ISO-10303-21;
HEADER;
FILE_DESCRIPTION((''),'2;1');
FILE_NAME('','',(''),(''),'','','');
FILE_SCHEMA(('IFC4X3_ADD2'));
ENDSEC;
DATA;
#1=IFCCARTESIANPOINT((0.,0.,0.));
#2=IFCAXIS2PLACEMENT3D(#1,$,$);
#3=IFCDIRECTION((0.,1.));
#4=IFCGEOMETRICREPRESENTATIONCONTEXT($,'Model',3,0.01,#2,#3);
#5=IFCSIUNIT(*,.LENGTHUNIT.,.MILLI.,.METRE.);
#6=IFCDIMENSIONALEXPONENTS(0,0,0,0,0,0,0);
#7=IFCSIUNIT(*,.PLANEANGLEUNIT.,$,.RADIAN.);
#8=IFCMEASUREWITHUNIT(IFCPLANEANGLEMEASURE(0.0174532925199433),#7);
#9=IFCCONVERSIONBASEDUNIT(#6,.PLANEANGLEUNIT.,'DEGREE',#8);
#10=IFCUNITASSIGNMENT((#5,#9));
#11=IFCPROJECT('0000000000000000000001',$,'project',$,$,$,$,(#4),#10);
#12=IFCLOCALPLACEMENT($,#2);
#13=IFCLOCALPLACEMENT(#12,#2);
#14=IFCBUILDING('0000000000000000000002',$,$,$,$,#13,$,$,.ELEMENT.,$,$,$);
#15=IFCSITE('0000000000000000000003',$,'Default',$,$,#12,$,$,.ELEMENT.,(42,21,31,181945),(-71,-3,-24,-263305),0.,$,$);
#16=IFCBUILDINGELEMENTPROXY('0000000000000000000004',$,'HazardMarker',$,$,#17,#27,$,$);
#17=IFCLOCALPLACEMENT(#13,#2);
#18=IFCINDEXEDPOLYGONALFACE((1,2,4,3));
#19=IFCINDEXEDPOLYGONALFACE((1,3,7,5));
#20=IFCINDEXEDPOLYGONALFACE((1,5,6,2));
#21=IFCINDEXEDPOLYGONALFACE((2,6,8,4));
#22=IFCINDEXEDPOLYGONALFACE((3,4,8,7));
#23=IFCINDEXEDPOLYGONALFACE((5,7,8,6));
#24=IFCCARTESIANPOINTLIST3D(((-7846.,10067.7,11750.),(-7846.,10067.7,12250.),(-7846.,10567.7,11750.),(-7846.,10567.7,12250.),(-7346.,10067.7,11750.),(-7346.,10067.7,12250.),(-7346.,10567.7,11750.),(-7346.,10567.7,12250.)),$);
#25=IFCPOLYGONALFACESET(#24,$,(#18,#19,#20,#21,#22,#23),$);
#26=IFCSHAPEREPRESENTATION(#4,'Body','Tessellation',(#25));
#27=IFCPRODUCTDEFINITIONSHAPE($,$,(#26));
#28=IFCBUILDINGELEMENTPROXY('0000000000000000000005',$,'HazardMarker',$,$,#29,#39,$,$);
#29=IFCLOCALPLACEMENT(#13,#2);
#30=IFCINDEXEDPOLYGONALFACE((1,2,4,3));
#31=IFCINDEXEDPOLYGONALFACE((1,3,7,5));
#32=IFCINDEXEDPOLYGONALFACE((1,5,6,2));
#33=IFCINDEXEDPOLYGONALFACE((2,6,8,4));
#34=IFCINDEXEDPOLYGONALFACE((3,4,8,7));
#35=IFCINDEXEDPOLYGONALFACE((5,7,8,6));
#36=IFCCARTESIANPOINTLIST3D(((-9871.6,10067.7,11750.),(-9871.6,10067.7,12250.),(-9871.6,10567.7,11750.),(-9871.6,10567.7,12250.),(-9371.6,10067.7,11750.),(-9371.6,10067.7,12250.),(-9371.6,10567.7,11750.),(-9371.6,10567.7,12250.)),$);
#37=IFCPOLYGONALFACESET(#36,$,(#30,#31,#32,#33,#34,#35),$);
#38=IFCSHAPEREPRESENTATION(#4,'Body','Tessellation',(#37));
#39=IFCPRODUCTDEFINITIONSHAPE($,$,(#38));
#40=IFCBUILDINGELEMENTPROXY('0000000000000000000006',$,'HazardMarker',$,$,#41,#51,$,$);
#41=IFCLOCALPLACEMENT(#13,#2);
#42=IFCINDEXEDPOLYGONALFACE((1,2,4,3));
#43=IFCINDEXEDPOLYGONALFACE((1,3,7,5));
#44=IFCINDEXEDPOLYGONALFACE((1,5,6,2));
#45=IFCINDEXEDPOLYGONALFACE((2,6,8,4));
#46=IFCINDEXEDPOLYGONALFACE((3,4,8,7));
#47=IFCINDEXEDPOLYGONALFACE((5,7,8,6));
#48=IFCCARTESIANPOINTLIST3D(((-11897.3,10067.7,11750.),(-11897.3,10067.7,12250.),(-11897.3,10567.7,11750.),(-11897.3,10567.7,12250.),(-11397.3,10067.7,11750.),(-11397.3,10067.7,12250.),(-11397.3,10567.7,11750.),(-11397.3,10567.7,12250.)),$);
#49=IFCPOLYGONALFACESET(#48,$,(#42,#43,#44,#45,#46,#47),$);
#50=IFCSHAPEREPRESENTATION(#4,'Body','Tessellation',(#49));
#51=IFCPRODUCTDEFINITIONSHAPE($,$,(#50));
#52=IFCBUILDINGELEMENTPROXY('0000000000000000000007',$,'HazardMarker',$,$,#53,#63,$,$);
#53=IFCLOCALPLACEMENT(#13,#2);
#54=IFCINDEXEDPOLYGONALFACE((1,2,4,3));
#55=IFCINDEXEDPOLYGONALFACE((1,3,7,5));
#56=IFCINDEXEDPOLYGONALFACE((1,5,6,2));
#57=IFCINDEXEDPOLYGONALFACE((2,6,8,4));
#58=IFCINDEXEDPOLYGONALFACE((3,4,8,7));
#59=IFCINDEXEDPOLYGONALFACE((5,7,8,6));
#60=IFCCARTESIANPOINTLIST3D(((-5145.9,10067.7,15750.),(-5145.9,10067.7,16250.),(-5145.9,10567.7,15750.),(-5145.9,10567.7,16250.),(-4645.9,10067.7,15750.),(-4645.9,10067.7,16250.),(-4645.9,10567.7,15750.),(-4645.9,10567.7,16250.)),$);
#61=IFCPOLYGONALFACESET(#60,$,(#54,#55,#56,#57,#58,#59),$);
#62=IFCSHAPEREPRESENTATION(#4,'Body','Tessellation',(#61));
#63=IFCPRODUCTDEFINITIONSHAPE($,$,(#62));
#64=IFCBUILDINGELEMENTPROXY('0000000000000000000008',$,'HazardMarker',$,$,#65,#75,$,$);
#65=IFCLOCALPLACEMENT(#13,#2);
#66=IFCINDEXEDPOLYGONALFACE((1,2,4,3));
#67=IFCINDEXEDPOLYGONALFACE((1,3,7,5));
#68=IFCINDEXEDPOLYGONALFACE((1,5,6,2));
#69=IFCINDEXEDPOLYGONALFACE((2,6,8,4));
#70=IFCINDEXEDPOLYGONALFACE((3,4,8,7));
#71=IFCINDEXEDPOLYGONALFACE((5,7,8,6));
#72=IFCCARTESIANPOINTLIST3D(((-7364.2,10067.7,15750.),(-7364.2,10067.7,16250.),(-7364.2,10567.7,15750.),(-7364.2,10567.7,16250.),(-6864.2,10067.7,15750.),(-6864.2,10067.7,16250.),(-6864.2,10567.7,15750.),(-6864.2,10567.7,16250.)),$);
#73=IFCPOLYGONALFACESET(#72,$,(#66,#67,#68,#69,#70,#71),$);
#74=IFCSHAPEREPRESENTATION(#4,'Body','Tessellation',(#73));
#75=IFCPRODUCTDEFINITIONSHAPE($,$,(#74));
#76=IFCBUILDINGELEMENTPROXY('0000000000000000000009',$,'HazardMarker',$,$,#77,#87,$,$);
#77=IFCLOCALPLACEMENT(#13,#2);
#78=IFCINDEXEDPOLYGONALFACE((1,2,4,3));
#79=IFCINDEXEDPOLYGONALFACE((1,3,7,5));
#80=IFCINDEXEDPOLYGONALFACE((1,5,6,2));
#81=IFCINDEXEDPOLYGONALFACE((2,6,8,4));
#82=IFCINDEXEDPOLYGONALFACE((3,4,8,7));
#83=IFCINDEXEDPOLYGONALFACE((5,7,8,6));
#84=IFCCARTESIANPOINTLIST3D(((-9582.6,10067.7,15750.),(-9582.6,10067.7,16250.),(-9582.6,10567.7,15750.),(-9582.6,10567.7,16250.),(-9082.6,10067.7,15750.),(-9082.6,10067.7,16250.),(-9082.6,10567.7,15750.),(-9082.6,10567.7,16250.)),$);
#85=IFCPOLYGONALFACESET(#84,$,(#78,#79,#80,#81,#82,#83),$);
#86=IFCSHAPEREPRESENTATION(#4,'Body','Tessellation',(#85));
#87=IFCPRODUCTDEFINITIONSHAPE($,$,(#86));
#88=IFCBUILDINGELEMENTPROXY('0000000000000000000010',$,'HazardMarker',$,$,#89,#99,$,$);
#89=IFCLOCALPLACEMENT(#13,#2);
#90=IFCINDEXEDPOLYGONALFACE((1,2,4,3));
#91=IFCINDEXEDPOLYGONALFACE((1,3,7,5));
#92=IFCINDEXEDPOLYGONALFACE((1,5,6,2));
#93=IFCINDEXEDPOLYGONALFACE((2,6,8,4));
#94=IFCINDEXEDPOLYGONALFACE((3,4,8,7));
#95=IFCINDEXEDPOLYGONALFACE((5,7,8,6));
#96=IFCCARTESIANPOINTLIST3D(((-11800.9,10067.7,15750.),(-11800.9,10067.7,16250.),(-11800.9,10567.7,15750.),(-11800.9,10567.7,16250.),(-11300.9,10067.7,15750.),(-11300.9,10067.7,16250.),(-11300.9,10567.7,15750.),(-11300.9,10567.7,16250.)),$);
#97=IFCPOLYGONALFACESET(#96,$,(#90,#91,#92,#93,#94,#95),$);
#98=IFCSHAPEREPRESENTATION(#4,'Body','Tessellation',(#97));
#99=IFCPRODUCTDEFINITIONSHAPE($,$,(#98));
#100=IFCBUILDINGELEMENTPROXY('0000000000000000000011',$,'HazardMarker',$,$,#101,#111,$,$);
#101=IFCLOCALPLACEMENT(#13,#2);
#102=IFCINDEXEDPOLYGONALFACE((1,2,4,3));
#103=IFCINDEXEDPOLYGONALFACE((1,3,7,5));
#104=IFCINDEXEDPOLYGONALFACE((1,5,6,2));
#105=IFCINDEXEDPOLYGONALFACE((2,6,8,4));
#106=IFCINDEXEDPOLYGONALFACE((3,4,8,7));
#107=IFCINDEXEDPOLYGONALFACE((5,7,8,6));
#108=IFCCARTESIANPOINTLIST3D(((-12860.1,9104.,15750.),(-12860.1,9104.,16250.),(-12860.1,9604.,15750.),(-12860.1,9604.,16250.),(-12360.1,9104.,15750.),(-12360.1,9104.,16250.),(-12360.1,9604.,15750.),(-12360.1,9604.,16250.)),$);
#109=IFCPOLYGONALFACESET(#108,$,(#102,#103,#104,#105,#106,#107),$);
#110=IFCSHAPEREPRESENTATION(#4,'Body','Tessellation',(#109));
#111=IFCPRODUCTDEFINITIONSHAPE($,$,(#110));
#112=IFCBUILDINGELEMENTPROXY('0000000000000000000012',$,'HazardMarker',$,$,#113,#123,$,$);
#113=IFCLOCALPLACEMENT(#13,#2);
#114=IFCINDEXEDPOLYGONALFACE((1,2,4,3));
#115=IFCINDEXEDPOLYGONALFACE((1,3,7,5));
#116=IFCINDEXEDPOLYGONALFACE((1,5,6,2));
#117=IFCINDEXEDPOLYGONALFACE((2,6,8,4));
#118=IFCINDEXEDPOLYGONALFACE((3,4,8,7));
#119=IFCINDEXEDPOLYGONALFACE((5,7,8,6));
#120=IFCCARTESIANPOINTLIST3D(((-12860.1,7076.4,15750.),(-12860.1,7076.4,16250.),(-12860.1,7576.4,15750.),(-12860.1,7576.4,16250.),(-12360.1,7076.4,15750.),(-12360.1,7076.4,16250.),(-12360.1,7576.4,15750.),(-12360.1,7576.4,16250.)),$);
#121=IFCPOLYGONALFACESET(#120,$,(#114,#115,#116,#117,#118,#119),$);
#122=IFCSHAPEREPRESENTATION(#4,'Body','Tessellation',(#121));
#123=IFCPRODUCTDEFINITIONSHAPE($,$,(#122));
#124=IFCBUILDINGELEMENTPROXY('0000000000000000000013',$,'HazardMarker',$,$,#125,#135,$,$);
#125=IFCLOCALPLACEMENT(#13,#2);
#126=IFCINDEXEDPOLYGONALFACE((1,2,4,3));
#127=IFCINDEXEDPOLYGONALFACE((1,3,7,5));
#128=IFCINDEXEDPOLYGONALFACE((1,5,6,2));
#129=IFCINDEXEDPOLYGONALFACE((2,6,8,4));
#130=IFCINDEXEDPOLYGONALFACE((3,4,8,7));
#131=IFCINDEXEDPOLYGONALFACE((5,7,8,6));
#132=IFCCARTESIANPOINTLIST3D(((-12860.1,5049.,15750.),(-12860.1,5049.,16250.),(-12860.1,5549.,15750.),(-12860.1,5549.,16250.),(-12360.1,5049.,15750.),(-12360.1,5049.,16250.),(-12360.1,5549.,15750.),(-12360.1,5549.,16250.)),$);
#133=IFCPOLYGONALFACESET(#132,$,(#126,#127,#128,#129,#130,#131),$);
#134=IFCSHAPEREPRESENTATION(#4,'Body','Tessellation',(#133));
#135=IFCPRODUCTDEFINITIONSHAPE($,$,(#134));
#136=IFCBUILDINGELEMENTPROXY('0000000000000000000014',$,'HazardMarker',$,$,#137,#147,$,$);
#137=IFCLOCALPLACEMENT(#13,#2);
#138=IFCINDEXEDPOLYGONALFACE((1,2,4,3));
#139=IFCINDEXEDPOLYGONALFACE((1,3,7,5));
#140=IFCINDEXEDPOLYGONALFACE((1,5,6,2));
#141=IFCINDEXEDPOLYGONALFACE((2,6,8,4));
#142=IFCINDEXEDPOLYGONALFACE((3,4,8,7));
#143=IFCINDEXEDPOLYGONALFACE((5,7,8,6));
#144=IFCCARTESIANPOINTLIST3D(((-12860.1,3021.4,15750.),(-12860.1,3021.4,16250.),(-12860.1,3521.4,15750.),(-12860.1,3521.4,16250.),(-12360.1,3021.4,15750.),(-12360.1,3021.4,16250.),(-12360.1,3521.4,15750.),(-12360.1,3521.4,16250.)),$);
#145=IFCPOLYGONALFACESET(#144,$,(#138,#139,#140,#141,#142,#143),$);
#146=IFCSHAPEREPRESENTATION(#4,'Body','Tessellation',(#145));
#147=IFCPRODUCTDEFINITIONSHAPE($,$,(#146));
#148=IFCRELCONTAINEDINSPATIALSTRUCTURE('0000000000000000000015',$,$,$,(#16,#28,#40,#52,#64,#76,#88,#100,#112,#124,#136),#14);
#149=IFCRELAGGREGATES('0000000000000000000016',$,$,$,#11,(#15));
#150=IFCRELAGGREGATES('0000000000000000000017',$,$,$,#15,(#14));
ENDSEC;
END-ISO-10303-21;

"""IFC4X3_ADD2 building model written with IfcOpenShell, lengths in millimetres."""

from ifc_helpers import new_model, entity, si_unit, converted_unit, direction, frame, origin, place, context, project, spatial, rectangle, extrude, element, save


model = new_model("IFC4X3_ADD2")

# Units and contexts
model_context = context("Model", 3, precision=0.01, world=origin(), true_north=direction((0.0, 1.0)))
ifc_project = project(units=[si_unit("LENGTHUNIT", "METRE", prefix="MILLI"), converted_unit("PLANEANGLEUNIT", "DEGREE", entity("IfcPlaneAngleMeasure", 0.0174532925199433), si_unit("PLANEANGLEUNIT", "RADIAN"), dimensions=[0, 0, 0, 0, 0, 0, 0])], contexts=[model_context])

# Site, building
site_placement = place(None, origin())
site = spatial("IfcSite", under=ifc_project, at=site_placement, Name="Default", CompositionType="ELEMENT", RefLatitude=(42, 21, 31, 181945), RefLongitude=(-71, -3, -24, -263305), RefElevation=0.0)
building_placement = place(site_placement, origin())
building = spatial("IfcBuilding", under=site, at=building_placement, CompositionType="ELEMENT")

# Building element proxies
for number, where, name in (
    (1, (-7596.0, 10317.7, 12000.0), "HazardMarker"),
    (2, (-9621.6, 10317.7, 12000.0), "HazardMarker"),
    (3, (-11647.3, 10317.7, 12000.0), "HazardMarker"),
    (4, (-4895.9, 10317.7, 16000.0), "HazardMarker"),
    (5, (-7114.2, 10317.7, 16000.0), "HazardMarker"),
    (6, (-9332.6, 10317.7, 16000.0), "HazardMarker"),
    (7, (-11550.9, 10317.7, 16000.0), "HazardMarker"),
    (8, (-12610.1, 9354.0, 16000.0), "HazardMarker"),
    (9, (-12610.1, 7326.4, 16000.0), "HazardMarker"),
    (10, (-12610.1, 5298.9, 16000.0), "HazardMarker"),
    (11, (-12610.1, 3271.4, 16000.0), "HazardMarker"),
):
    element("IfcBuildingElementProxy", number, at=place(None, frame(where)), inside=building, Name=name, context=model_context, shape_type="SweptSolid", body=[
        extrude(rectangle(XDim=500.0, YDim=500.0), frame((0.0, 0.0, -250.0)), (0.0, 0.0, 1.0), 500.0),
    ])

save(model, "model.ifc")
